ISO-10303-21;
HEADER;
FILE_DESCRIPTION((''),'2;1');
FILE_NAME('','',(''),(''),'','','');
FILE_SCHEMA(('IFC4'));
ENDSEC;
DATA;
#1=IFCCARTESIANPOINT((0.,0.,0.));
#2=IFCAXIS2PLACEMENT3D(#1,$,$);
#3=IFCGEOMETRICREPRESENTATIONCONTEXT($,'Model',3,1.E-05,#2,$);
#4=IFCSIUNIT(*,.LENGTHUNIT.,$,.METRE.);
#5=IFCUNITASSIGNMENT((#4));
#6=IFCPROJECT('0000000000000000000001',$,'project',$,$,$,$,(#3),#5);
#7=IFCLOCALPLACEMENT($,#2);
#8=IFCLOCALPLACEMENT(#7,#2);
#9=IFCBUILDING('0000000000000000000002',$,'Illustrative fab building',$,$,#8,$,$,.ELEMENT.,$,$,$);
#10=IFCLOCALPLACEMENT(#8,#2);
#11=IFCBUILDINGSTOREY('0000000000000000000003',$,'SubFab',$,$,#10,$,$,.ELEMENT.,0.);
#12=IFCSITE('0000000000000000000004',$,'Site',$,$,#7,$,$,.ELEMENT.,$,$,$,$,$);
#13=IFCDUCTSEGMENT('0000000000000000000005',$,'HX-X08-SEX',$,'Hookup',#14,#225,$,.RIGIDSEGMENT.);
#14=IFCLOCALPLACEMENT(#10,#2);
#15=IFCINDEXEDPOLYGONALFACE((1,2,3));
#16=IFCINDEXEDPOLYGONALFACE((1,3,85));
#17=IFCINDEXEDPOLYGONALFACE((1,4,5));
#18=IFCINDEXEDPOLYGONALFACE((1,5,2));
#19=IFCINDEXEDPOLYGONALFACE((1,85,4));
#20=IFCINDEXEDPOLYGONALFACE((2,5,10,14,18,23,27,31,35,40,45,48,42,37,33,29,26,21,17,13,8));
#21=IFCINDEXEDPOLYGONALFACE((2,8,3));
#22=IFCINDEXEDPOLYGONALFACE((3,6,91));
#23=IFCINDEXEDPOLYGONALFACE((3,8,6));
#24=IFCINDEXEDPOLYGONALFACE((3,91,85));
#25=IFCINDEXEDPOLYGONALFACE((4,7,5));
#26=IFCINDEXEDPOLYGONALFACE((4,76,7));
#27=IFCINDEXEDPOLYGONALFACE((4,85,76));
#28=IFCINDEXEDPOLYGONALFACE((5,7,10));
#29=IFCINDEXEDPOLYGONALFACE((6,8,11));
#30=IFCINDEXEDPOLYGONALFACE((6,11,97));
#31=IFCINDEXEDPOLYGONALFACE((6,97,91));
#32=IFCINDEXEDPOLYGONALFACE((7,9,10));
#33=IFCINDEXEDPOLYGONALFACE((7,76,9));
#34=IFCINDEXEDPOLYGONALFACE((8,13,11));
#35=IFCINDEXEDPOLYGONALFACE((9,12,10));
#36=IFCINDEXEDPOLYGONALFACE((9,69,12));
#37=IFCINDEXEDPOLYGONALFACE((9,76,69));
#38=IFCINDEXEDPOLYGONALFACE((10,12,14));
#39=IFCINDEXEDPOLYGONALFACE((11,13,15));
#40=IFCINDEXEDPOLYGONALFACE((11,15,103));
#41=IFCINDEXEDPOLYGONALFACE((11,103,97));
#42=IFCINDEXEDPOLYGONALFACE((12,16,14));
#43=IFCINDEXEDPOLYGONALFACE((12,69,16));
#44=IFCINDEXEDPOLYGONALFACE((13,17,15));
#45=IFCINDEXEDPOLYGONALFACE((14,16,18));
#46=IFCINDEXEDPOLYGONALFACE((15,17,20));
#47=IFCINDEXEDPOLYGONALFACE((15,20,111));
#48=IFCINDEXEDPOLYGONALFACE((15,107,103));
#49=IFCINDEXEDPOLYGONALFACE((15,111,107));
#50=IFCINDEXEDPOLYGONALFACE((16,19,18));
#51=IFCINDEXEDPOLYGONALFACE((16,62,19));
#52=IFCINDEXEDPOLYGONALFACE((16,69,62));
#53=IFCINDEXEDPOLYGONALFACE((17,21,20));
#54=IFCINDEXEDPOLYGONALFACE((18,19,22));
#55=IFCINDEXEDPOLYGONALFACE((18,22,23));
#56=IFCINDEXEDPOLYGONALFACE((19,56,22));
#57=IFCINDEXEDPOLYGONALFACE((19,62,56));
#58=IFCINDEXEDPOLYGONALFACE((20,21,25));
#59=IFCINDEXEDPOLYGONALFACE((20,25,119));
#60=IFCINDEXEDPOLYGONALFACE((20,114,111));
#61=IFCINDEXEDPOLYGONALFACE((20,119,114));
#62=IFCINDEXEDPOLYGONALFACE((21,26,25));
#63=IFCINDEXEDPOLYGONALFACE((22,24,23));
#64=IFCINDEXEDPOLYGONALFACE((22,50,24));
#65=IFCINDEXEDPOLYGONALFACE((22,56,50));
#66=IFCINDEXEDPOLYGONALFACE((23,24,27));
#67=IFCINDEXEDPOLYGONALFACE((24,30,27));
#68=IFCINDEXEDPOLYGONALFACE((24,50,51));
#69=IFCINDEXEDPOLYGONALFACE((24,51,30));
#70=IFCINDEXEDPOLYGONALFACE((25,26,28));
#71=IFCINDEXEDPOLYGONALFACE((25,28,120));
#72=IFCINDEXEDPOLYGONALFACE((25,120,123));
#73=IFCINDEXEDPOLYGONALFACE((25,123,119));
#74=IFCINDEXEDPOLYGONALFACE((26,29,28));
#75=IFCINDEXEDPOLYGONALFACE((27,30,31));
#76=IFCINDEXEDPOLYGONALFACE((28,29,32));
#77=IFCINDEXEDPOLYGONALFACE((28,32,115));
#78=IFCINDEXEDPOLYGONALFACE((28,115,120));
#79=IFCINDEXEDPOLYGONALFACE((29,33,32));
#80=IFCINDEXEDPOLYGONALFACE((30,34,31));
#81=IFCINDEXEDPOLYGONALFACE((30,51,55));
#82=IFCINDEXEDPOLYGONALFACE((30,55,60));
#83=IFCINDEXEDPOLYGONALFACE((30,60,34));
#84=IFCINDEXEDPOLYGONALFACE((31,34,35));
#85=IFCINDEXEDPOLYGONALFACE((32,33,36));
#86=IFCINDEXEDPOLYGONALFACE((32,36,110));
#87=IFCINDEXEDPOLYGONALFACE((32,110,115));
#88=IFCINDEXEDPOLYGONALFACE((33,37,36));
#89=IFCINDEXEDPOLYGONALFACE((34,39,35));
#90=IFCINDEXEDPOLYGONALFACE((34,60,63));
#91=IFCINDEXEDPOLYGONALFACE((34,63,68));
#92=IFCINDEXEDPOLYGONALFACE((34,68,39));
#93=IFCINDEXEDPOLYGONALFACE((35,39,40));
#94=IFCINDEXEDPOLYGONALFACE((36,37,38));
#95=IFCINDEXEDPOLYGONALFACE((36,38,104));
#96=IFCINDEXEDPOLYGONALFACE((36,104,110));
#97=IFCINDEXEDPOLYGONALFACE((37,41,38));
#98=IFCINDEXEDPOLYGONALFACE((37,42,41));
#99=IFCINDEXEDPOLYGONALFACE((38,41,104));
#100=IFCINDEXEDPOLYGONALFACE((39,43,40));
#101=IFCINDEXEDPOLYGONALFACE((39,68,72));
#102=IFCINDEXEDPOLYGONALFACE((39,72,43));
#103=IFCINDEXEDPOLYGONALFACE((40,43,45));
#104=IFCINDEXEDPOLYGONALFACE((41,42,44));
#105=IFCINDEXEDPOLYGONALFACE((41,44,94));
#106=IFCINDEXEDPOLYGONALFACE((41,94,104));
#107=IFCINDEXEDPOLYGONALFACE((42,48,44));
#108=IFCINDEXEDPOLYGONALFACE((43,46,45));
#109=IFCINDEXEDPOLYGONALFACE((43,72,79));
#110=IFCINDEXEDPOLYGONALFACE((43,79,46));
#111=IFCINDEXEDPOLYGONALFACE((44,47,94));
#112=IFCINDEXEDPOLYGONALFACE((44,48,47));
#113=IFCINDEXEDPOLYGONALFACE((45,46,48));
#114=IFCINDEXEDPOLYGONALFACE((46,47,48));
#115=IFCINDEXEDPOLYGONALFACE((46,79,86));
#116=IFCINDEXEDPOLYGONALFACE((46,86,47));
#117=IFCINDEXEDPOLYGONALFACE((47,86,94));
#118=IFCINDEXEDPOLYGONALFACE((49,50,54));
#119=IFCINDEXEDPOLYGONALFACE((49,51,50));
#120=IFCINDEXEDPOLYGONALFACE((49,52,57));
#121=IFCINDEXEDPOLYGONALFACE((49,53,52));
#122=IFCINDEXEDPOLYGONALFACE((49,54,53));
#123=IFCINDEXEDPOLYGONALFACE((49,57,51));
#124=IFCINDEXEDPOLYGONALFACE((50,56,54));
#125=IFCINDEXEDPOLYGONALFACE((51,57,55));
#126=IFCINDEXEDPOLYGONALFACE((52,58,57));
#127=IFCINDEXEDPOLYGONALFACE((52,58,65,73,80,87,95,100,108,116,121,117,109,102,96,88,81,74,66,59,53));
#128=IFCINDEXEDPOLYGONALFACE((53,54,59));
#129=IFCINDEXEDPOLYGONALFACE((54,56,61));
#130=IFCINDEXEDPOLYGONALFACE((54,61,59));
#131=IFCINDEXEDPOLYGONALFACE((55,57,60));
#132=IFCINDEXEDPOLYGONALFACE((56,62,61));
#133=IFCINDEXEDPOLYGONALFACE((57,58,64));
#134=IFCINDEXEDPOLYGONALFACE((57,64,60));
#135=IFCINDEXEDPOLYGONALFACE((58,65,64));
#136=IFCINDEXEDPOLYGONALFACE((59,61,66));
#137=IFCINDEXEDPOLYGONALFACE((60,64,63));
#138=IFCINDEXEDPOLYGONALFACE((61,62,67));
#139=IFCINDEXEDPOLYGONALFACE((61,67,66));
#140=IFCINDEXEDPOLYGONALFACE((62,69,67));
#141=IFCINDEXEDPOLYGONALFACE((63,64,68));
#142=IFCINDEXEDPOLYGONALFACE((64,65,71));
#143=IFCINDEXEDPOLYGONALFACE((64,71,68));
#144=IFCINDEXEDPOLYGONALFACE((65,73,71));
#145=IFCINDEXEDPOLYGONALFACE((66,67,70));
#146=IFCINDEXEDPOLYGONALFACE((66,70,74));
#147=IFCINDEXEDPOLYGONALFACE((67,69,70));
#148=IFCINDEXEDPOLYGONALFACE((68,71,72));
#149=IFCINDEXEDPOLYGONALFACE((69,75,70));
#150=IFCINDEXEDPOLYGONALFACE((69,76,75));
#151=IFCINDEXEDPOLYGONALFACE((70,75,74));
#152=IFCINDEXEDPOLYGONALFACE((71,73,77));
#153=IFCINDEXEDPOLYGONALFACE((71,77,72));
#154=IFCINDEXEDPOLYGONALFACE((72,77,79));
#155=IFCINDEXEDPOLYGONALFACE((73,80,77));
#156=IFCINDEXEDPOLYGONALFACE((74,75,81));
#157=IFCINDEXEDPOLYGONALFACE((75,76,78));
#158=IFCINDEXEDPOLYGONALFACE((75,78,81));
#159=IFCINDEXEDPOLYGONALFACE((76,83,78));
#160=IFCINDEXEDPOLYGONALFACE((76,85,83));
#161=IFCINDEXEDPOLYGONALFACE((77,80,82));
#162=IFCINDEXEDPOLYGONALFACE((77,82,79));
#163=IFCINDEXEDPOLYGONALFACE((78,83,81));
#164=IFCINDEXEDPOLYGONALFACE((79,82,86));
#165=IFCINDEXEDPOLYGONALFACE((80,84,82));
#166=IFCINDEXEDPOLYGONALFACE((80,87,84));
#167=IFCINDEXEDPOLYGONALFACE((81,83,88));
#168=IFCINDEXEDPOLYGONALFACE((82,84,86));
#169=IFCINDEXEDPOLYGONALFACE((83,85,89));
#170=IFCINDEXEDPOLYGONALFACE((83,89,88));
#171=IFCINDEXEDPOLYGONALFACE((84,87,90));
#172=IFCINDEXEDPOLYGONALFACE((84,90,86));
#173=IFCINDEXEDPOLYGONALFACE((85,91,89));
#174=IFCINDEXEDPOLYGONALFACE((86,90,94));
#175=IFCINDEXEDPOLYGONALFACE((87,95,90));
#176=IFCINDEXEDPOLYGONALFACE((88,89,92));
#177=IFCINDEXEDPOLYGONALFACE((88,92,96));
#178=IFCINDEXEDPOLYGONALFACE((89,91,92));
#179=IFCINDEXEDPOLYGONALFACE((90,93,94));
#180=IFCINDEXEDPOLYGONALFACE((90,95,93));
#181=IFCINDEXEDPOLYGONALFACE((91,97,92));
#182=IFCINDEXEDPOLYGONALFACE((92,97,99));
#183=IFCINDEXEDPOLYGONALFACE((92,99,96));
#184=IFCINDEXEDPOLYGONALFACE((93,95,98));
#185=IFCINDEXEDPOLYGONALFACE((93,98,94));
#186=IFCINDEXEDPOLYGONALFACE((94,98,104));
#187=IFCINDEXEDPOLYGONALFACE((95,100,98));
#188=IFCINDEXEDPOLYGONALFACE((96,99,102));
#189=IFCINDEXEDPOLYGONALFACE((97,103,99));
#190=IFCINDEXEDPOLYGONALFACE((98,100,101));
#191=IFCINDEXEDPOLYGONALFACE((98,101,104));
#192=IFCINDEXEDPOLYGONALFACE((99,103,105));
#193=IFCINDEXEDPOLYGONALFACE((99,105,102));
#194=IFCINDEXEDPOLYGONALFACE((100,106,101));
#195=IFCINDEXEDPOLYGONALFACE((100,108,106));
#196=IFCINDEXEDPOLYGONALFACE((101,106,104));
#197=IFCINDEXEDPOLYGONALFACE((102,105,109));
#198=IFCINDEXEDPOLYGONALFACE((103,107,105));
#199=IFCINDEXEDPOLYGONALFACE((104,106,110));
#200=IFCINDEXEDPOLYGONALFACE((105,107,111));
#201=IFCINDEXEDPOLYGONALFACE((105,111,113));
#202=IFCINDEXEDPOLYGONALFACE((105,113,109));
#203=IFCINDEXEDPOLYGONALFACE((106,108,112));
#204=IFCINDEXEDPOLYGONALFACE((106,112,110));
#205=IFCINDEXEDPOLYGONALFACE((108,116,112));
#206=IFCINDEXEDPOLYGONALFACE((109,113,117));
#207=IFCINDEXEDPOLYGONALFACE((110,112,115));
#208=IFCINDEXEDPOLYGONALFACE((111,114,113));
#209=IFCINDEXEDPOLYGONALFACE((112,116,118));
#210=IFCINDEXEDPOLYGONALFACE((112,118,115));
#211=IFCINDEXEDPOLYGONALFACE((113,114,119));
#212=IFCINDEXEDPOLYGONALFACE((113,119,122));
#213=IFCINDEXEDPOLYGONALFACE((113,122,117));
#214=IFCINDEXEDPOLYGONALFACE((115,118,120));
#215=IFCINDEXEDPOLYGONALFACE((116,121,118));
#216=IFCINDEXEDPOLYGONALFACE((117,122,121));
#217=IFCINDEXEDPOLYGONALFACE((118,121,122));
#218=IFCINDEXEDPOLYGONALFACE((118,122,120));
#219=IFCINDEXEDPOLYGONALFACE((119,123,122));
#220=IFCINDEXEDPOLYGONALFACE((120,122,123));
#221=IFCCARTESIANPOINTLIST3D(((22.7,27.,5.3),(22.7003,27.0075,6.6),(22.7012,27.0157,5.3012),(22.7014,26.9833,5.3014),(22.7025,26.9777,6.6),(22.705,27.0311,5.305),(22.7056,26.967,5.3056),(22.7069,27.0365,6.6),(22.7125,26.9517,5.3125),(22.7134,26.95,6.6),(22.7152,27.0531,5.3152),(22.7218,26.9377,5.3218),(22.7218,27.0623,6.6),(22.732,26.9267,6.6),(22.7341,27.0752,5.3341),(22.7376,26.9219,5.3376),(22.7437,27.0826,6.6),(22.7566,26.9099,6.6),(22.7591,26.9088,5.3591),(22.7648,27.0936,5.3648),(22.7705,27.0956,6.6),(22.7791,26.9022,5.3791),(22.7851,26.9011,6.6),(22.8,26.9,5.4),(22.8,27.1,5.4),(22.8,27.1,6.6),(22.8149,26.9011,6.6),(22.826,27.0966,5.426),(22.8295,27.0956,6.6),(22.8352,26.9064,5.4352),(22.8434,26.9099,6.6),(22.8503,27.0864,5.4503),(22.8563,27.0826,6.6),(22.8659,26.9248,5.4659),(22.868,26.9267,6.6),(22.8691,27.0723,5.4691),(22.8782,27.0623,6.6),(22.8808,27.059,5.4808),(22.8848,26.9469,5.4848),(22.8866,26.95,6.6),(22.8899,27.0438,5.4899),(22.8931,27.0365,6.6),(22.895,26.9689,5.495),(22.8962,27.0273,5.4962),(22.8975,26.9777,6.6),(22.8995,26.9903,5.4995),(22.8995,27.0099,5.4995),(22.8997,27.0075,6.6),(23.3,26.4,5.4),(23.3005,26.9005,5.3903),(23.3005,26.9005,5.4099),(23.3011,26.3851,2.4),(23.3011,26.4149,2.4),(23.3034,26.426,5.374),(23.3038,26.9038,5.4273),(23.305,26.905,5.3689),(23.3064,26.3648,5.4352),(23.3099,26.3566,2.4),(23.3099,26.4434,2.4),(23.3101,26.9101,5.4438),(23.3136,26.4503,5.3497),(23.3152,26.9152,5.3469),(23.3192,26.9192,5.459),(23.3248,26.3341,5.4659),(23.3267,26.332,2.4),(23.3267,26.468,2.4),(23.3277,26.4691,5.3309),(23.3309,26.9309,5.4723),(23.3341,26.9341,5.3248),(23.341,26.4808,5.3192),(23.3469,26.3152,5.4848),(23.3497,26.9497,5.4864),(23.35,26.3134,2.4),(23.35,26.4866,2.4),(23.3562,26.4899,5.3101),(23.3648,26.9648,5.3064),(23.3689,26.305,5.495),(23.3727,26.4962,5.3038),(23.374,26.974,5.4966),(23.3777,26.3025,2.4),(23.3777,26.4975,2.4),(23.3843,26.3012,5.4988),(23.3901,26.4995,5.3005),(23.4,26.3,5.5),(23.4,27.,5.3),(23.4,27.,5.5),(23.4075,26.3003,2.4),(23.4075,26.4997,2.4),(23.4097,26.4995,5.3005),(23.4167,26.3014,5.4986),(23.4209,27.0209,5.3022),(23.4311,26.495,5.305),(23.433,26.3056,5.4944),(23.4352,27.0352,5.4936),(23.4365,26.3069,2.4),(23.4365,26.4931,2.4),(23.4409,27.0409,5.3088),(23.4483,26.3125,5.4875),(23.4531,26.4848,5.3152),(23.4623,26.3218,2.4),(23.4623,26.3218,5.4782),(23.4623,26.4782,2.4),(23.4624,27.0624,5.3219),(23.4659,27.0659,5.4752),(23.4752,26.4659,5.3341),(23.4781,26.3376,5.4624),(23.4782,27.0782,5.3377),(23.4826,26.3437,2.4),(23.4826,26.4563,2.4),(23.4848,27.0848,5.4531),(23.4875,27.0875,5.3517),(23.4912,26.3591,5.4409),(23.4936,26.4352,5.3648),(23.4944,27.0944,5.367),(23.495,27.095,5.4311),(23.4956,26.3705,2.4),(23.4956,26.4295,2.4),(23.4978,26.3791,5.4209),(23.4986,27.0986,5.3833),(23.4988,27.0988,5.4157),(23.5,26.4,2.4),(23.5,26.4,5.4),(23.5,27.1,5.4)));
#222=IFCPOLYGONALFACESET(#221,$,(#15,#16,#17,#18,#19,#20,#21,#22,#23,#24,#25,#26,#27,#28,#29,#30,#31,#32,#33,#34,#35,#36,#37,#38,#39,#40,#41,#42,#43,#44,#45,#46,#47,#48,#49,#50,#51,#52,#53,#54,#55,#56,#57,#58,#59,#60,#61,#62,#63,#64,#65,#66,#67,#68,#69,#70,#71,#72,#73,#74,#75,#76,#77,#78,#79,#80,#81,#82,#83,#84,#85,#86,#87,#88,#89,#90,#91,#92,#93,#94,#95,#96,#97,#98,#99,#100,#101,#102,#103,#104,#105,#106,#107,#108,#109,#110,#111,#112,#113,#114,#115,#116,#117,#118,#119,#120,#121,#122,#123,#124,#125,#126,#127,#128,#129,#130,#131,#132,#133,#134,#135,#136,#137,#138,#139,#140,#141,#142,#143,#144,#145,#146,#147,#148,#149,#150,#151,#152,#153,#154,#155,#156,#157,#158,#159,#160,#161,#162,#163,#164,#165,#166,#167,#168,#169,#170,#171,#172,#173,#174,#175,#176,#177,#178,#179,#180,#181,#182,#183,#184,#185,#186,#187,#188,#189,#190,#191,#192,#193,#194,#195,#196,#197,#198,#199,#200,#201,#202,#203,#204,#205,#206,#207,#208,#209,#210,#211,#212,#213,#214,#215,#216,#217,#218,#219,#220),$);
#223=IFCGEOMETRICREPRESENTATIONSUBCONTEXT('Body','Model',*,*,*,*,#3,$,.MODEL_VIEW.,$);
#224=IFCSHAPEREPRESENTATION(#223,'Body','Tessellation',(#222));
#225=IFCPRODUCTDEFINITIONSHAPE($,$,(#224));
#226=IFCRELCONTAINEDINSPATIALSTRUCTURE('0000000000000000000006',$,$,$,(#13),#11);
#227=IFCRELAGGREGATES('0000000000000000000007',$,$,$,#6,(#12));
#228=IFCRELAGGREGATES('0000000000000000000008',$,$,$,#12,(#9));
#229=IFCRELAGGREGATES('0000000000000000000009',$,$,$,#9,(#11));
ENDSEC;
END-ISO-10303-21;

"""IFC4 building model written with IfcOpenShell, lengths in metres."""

from ifc_helpers import new_model, entity, si_unit, origin, place, context, subcontext, project, spatial, element, save


model = new_model("IFC4")

# Units and contexts
model_context = context("Model", 3, precision=1e-05, world=origin())
body_context = subcontext(model_context, "Body", "Model", "MODEL_VIEW")
ifc_project = project(units=[si_unit("LENGTHUNIT", "METRE")], contexts=[model_context])

# Site, building, storey
site_placement = place(None, origin())
site = spatial("IfcSite", under=ifc_project, at=site_placement, Name="Site", CompositionType="ELEMENT")
building_placement = place(site_placement, origin())
building = spatial("IfcBuilding", under=site, at=building_placement, Name="Illustrative fab building", CompositionType="ELEMENT")
storey_placement = place(building_placement, origin())
storey = spatial("IfcBuildingStorey", under=building, at=storey_placement, Name="SubFab", CompositionType="ELEMENT", Elevation=0.0)

# Duct segment
duct_segment_1_placement = place(storey_placement, origin())
element("IfcDuctSegment", 1, at=duct_segment_1_placement, inside=storey, Name="HX-X08-SEX", ObjectType="Hookup", PredefinedType="RIGIDSEGMENT", context=body_context, shape_type="AdvancedSweptSolid", body=[
    entity("IfcSweptDiskSolid", entity("IfcPolyline", [entity("IfcCartesianPoint", [23.4, 26.4, 2.4]), entity("IfcCartesianPoint", [23.4, 26.4, 5.4]), entity("IfcCartesianPoint", [23.4, 27.0, 5.4]), entity("IfcCartesianPoint", [22.8, 27.0, 5.4]), entity("IfcCartesianPoint", [22.8, 27.0, 6.6])]), 0.1),
])

save(model, "model.ifc")
